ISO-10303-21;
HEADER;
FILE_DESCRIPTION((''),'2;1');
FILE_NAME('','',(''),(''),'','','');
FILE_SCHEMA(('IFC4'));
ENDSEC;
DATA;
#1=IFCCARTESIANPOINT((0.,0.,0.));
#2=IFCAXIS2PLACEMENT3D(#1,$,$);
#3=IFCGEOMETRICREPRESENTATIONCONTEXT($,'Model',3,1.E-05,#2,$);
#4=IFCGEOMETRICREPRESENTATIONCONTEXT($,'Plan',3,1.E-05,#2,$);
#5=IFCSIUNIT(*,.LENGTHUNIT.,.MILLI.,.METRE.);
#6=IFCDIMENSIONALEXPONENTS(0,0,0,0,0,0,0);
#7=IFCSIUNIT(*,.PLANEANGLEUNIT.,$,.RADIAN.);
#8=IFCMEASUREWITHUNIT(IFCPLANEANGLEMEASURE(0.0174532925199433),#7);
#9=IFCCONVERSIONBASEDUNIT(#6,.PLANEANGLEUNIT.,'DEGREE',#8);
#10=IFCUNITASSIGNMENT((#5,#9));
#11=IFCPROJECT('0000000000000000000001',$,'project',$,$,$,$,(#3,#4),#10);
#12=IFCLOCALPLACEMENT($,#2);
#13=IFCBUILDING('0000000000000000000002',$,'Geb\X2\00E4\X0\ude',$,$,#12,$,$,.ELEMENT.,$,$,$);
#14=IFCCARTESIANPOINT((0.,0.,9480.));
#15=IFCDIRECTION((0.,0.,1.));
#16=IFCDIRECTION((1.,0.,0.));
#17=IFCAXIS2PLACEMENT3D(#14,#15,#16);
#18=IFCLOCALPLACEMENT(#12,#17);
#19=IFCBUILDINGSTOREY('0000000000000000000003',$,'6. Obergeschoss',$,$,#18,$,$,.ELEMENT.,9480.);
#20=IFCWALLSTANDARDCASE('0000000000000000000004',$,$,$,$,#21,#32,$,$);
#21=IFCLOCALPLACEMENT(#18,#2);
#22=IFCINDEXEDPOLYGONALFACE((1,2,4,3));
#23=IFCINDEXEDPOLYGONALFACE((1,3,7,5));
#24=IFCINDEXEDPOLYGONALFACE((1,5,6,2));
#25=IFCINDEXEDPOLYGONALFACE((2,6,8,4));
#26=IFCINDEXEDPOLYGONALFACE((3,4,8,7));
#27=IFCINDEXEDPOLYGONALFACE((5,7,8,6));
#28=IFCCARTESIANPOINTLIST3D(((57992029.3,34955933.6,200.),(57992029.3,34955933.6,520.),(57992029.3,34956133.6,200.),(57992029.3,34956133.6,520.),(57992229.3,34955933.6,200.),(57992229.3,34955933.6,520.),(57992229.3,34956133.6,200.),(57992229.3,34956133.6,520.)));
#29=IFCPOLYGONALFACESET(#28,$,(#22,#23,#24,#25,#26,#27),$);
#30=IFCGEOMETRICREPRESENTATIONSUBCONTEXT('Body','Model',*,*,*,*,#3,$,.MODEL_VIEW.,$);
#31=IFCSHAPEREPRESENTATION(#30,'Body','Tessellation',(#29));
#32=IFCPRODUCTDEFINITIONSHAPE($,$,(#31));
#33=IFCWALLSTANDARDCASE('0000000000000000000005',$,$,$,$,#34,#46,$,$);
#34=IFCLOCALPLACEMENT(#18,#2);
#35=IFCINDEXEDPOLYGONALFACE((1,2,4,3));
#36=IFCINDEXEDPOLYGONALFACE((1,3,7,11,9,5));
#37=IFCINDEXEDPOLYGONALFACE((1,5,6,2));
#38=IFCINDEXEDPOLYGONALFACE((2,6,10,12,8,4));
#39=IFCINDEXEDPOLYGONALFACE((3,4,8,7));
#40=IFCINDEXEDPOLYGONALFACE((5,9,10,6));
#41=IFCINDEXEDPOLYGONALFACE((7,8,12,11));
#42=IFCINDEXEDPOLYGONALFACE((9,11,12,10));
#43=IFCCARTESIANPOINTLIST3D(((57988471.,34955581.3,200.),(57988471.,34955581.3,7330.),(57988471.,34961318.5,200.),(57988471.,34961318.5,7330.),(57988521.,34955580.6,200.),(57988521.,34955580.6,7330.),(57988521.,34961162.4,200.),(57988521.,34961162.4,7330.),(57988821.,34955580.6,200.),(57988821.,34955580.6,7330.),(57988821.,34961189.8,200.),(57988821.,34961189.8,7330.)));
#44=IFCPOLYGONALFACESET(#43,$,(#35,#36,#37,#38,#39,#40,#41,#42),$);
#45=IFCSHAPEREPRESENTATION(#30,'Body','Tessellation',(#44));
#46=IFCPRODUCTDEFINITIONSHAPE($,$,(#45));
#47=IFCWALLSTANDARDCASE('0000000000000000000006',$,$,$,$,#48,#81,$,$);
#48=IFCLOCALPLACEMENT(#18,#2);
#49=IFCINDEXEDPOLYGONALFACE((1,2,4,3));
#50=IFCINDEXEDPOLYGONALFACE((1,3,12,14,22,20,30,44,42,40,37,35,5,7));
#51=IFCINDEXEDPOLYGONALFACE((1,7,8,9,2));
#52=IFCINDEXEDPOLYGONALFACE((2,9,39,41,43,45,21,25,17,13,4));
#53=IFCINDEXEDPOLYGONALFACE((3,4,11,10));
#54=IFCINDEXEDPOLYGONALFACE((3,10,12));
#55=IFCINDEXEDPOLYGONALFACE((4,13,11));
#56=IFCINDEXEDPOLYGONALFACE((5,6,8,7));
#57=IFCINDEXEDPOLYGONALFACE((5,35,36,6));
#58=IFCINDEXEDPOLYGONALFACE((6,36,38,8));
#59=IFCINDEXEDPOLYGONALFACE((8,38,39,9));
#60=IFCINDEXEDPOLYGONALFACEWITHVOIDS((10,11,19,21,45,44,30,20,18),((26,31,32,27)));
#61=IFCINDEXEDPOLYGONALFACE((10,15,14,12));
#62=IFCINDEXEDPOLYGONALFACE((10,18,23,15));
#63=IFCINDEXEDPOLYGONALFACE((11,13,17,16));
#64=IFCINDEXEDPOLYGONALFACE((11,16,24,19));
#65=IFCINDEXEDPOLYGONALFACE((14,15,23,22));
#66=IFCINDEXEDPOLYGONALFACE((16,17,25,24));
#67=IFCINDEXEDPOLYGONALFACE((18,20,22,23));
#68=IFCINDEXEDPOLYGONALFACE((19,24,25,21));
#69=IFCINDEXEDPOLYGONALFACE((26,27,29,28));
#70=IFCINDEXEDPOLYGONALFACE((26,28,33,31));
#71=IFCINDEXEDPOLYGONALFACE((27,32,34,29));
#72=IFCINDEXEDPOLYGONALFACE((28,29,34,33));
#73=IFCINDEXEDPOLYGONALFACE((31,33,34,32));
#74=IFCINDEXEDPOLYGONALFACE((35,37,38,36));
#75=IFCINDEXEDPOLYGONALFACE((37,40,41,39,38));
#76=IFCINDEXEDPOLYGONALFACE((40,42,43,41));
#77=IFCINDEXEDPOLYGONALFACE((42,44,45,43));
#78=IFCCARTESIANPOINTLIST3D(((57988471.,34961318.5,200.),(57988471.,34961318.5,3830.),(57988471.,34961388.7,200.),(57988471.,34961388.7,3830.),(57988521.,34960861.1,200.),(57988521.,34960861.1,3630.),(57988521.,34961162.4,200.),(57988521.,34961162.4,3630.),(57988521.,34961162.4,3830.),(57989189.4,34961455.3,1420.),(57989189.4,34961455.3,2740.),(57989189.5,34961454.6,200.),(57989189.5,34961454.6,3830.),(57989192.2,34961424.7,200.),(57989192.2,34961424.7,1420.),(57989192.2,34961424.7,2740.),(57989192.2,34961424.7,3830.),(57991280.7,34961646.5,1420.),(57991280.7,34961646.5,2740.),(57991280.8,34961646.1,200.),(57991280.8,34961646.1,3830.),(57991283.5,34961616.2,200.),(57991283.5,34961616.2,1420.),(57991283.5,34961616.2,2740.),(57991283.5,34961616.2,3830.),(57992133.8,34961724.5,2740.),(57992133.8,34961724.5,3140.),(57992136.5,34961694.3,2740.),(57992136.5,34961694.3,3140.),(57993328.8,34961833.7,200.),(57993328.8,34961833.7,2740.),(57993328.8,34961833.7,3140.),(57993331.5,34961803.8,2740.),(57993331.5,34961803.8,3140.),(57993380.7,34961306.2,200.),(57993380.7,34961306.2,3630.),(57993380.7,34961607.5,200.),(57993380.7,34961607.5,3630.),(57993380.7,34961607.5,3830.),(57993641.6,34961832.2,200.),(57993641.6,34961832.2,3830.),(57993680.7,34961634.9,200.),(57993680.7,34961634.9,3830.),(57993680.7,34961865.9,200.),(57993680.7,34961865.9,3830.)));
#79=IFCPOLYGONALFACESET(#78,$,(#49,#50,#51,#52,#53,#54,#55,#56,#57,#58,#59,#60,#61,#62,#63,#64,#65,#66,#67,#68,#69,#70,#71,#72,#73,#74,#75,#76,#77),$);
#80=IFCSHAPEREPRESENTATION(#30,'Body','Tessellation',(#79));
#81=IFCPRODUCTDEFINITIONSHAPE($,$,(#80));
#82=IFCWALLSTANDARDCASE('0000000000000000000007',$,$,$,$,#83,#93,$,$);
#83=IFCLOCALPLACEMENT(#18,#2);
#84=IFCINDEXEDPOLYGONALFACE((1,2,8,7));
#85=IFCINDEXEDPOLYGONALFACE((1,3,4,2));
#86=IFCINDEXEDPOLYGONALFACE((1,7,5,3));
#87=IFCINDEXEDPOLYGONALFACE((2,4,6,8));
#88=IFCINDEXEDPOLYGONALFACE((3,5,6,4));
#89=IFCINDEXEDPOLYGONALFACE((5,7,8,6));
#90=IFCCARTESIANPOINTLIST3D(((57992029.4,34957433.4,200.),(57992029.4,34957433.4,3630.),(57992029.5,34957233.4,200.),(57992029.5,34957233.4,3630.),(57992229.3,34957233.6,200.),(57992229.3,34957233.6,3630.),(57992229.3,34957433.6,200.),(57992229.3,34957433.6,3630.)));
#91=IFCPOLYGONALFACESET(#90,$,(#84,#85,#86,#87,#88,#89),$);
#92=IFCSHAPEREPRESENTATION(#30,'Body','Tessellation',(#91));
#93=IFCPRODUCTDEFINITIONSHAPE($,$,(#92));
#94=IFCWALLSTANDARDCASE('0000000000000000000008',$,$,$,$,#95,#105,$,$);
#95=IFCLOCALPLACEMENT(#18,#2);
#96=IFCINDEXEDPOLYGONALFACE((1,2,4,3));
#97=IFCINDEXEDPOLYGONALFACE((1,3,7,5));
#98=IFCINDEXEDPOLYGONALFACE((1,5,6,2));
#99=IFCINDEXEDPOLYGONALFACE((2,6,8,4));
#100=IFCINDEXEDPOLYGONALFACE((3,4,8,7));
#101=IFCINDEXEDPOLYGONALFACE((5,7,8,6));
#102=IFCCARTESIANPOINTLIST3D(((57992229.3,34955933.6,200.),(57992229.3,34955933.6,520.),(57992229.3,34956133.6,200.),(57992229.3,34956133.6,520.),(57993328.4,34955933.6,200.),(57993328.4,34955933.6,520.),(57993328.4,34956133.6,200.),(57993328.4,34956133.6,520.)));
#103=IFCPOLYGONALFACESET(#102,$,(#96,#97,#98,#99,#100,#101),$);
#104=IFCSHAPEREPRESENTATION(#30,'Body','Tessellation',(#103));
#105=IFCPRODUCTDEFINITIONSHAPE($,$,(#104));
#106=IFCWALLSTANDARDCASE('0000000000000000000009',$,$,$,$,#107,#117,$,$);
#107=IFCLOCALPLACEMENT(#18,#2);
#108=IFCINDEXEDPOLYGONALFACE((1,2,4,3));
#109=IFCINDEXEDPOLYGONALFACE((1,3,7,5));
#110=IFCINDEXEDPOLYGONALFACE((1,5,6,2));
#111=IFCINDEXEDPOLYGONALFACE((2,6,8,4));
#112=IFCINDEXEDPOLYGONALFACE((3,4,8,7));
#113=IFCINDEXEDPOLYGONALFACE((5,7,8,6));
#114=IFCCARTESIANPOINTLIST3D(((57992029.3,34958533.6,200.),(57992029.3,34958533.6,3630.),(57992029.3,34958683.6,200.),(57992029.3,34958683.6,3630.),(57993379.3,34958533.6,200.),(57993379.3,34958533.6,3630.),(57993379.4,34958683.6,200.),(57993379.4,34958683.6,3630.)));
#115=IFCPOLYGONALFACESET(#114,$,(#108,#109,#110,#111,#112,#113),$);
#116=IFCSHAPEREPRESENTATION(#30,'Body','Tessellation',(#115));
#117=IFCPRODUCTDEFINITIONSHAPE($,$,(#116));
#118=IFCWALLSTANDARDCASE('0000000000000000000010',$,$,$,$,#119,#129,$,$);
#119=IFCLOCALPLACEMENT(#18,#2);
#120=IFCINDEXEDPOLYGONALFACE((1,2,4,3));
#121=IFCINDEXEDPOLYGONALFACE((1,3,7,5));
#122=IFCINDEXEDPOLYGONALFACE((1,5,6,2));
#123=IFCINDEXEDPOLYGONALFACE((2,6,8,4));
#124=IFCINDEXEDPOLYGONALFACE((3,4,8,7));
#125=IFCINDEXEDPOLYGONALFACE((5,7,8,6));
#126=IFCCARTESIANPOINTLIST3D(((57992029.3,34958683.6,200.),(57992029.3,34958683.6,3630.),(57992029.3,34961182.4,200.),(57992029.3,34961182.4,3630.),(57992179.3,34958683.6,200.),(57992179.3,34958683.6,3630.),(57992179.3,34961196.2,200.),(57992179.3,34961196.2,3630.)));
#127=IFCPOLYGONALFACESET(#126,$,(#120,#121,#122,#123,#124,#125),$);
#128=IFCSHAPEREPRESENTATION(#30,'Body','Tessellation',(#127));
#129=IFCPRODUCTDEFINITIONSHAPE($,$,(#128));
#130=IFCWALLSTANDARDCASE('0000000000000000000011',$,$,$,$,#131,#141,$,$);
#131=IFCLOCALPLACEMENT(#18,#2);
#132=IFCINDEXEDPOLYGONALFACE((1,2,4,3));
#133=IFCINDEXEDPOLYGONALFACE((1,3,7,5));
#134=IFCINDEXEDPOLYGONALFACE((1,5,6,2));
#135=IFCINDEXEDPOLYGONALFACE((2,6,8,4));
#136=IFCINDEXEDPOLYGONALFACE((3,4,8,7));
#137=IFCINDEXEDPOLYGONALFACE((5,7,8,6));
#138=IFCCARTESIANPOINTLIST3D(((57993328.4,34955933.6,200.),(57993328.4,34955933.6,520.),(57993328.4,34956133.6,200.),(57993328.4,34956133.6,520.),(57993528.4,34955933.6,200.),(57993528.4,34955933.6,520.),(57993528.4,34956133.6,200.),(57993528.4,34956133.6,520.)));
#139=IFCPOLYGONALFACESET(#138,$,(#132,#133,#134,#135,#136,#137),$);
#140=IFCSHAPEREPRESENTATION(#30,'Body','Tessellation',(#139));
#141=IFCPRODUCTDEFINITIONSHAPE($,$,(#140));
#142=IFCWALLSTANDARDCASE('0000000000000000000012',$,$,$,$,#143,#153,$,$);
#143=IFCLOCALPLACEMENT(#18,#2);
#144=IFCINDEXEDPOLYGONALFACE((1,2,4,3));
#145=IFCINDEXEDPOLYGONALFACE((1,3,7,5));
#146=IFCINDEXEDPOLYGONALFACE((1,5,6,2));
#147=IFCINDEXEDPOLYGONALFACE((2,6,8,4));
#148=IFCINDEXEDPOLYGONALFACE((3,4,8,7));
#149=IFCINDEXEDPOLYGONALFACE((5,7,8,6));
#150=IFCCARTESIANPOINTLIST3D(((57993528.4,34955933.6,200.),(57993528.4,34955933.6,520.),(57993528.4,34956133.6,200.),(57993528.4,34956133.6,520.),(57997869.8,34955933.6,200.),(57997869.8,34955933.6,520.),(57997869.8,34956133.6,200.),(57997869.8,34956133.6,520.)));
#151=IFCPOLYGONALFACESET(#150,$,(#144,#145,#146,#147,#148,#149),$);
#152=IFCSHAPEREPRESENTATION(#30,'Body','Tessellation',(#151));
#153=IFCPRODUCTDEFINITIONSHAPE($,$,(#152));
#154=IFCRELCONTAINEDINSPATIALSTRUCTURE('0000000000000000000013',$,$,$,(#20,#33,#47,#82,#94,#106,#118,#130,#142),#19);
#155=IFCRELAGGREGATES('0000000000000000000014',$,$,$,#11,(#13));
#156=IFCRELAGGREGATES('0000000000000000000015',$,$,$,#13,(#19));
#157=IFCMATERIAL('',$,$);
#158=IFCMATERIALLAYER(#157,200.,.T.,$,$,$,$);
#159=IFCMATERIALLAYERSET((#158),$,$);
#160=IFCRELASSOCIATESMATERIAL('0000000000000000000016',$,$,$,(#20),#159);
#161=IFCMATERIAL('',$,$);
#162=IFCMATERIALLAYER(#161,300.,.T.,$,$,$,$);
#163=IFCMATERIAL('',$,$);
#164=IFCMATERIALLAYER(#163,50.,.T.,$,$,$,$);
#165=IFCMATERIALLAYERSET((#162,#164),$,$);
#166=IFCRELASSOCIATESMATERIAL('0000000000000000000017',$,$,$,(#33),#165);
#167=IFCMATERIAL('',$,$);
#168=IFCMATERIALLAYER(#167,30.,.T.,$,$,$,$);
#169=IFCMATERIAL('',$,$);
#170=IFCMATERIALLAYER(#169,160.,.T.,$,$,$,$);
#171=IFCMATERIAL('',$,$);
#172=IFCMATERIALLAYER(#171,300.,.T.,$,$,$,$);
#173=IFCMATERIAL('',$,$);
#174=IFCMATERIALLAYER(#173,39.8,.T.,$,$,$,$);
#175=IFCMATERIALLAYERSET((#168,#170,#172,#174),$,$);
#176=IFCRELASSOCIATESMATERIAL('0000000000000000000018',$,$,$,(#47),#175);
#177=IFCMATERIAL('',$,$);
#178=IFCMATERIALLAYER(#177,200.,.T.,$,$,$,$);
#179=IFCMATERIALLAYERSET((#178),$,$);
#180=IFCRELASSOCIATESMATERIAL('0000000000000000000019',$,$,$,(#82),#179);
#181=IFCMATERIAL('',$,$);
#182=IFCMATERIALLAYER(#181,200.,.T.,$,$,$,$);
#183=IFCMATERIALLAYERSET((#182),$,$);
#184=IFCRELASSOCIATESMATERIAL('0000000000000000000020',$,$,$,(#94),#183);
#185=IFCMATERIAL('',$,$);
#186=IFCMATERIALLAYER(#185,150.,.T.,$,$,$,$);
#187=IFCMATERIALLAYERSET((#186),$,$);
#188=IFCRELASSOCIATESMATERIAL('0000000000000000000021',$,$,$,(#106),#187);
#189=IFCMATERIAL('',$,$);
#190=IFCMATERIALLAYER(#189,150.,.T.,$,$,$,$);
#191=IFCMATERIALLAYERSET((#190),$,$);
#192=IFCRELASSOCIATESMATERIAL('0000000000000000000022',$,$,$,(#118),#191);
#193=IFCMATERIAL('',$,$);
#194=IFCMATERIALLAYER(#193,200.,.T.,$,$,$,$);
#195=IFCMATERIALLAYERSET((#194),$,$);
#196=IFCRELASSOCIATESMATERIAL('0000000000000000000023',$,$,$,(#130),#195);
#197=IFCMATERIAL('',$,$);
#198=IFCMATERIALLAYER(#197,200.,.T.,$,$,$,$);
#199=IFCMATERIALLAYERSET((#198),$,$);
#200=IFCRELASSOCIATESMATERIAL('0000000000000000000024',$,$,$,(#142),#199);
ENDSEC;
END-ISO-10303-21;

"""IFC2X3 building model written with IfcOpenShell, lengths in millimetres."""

from ifc_helpers import new_model, entity, si_unit, converted_unit, frame, frame_2d, origin, origin_with_axes, place, context, subcontext, project, spatial, polyline, rectangle, outline, extrude, clip, bounded_halfspace, material, layer, layer_set, layer_usage, element, save


model = new_model("IFC2X3")

# Units and contexts
model_context = context("Model", 3, precision=1e-05, world=origin())
plan_context = context("Plan", 3, precision=1e-05, world=origin())
body_context = subcontext(model_context, "Body", "Model", "MODEL_VIEW")
ifc_project = project(units=[si_unit("LENGTHUNIT", "METRE", prefix="MILLI"), converted_unit("PLANEANGLEUNIT", "DEGREE", entity("IfcPlaneAngleMeasure", 0.0174532925199433), si_unit("PLANEANGLEUNIT", "RADIAN"), dimensions=[0, 0, 0, 0, 0, 0, 0])], contexts=[model_context, plan_context])

# Building, storey
building_placement = place(None, origin())
building = spatial("IfcBuilding", under=ifc_project, at=building_placement, Name="Gebäude", CompositionType="ELEMENT")
storey_placement = place(building_placement, frame((0.0, 0.0, 9480.0), z_axis=(0.0, 0.0, 1.0), x_axis=(1.0, 0.0, 0.0)))
storey = spatial("IfcBuildingStorey", under=building, at=storey_placement, Name="6. Obergeschoss", CompositionType="ELEMENT", Elevation=9480.0)

# Walls
ifc_material_1 = material(Name="")
ifc_layer_1 = layer(ifc_material_1, 200.0, ventilated=True)
ifc_layer_set_1 = layer_set([ifc_layer_1])
ifc_layer_usage_1 = layer_usage(ifc_layer_set_1, "AXIS2", "POSITIVE", 0.0)
wall_1_placement = place(storey_placement, frame((57992029.3, 34955933.6, 200.0), z_axis=(0.0, 0.0, 1.0), x_axis=(1.0, 0.0, 0.0)))
element("IfcWallStandardCase", 1, at=wall_1_placement, inside=storey, material=ifc_layer_usage_1, context=body_context, shape_type="SweptSolid", body=[
    extrude(rectangle(XDim=200.0, YDim=200.0, at=frame_2d((100.0, 100.0), x_axis=(1.0, 0.0))), origin_with_axes(), (0.0, 0.0, 1.0), 320.0),
])
ifc_material_2 = material(Name="")
ifc_layer_2 = layer(ifc_material_2, 300.0, ventilated=True)
ifc_material_3 = material(Name="")
ifc_layer_3 = layer(ifc_material_3, 50.0, ventilated=True)
ifc_layer_set_2 = layer_set([ifc_layer_2, ifc_layer_3])
ifc_layer_usage_2 = layer_usage(ifc_layer_set_2, "AXIS2", "POSITIVE", 0.0)
wall_2_placement = place(storey_placement, frame((57988821.0, 34955580.6, 200.0), z_axis=(0.0, 0.0, 1.0), x_axis=(0.0, 1.0, 0.0)))
element("IfcWallStandardCase", 2, at=wall_2_placement, inside=storey, material=ifc_layer_usage_2, context=body_context, shape_type="SweptSolid", body=[
    extrude(outline(polyline([(0.0, 0.0), (5609.3, 0.0), (5581.8, 300.0), (5737.9, 350.0), (0.7, 350.0), (0.0, 300.0), (0.0, 0.0)])), origin_with_axes(), (0.0, 0.0, 1.0), 7130.0),
])

# Wall, openings
ifc_material_4 = material(Name="")
ifc_layer_4 = layer(ifc_material_4, 30.0, ventilated=True)
ifc_material_5 = material(Name="")
ifc_layer_5 = layer(ifc_material_5, 160.0, ventilated=True)
ifc_material_6 = material(Name="")
ifc_layer_6 = layer(ifc_material_6, 300.0, ventilated=True)
ifc_material_7 = material(Name="")
ifc_layer_7 = layer(ifc_material_7, 39.8, ventilated=True)
ifc_layer_set_3 = layer_set([ifc_layer_4, ifc_layer_5, ifc_layer_6, ifc_layer_7])
ifc_layer_usage_3 = layer_usage(ifc_layer_set_3, "AXIS2", "POSITIVE", 0.0)
wall_3_placement = place(storey_placement, frame((57989192.2, 34961424.7, 200.0), z_axis=(0.0, 0.0, 1.0), x_axis=(0.995832, 0.091206, 0.0)))
wall_3 = element("IfcWallStandardCase", 3, at=wall_3_placement, inside=storey, material=ifc_layer_usage_3, context=body_context, shape_type="Clipping", body=[
    clip(clip(extrude(outline(polyline([(4510.0, 30.0), (4461.5, 30.0), (4208.8, 30.0), (4156.6, 30.0), (-721.5, 30.0), (-724.2, 0.4), (-727.9, -40.0), (-692.3, -200.0), (-719.8, -500.0), (4160.2, -500.0), (4187.7, -200.0), (4468.0, 0.0), (4472.2, -40.0), (4489.0, -200.0), (4507.3, 0.0), (4510.0, 30.0)])), origin_with_axes(), (0.0, 0.0, 1.0), 3630.0), bounded_halfspace(frame((-719.8, -500.0, 3430.0), z_axis=(0.0, 0.0, -1.0), x_axis=(1.0, 0.0, 0.0)), True, origin(), polyline([(-719.8, -500.0), (4160.2, -500.0), (4187.7, -200.0), (-692.3, -200.0), (-719.8, -500.0)]))), bounded_halfspace(frame((-692.3, -200.0, 3630.0), z_axis=(0.0, 0.0, -1.0), x_axis=(1.0, 0.0, 0.0)), True, origin(), polyline([(-692.3, -200.0), (4187.7, -200.0), (4468.0, 0.0), (4489.0, -200.0), (4510.0, 30.0), (4461.5, 30.0), (4208.8, 30.0), (4156.6, 30.0), (-721.5, 30.0), (-727.9, -40.0), (-692.3, -200.0)]))),
])
opening_1_placement = place(wall_3_placement, frame((0.0, 0.0, 2540.0), z_axis=(0.0, 1.0, 0.0), x_axis=(0.0, 0.0, 1.0)))
element("IfcOpeningElement", 4, at=opening_1_placement, cuts=wall_3, ObjectType="Opening", context=body_context, shape_type="SweptSolid", body=[
    extrude(rectangle(XDim=1200.0, YDim=2100.0, at=frame_2d((600.0, 1050.0), x_axis=(1.0, 0.0))), origin_with_axes(), (0.0, 0.0, 1.0), 530.0),
])
opening_2_placement = place(wall_3_placement, frame((2956.6, 0.0, 2540.0), z_axis=(0.0, 1.0, 0.0), x_axis=(0.0, 0.0, 1.0)))
element("IfcOpeningElement", 5, at=opening_2_placement, cuts=wall_3, ObjectType="Opening", context=body_context, shape_type="SweptSolid", body=[
    extrude(rectangle(XDim=400.0, YDim=1200.0, at=frame_2d((200.0, 600.0), x_axis=(1.0, 0.0))), origin_with_axes(), (0.0, 0.0, 1.0), 530.0),
])
opening_3_placement = place(wall_3_placement, frame((0.0, 0.0, -420.0), z_axis=(0.0, 1.0, 0.0), x_axis=(0.0, 0.0, 1.0)))
element("IfcOpeningElement", 6, at=opening_3_placement, cuts=wall_3, ObjectType="Opening", context=body_context, shape_type="SweptSolid", body=[
    extrude(rectangle(XDim=1640.0, YDim=2100.0, at=frame_2d((820.0, 1050.0), x_axis=(1.0, 0.0))), origin_with_axes(), (0.0, 0.0, 1.0), 530.0),
])

# Walls
ifc_material_8 = material(Name="")
ifc_layer_8 = layer(ifc_material_8, 200.0, ventilated=True)
ifc_layer_set_4 = layer_set([ifc_layer_8])
ifc_layer_usage_4 = layer_usage(ifc_layer_set_4, "AXIS2", "POSITIVE", 0.0)
wall_4_placement = place(storey_placement, frame((57992229.3, 34957433.6, 200.0), z_axis=(0.0, 0.0, 1.0), x_axis=(-1.0, -0.000827, 0.0)))
element("IfcWallStandardCase", 7, at=wall_4_placement, inside=storey, material=ifc_layer_usage_4, context=body_context, shape_type="SweptSolid", body=[
    extrude(outline(polyline([(0.0, 0.0), (200.0, 0.0), (200.0, 200.0), (0.2, 200.0), (0.0, 0.0)])), origin_with_axes(), (0.0, 0.0, 1.0), 3430.0),
])
ifc_material_9 = material(Name="")
ifc_layer_9 = layer(ifc_material_9, 200.0, ventilated=True)
ifc_layer_set_5 = layer_set([ifc_layer_9])
ifc_layer_usage_5 = layer_usage(ifc_layer_set_5, "AXIS2", "POSITIVE", 0.0)
wall_5_placement = place(storey_placement, frame((57992229.3, 34955933.6, 200.0), z_axis=(0.0, 0.0, 1.0), x_axis=(1.0, 0.0, 0.0)))
element("IfcWallStandardCase", 8, at=wall_5_placement, inside=storey, material=ifc_layer_usage_5, context=body_context, shape_type="SweptSolid", body=[
    extrude(rectangle(XDim=1099.1, YDim=200.0, at=frame_2d((549.6, 100.0), x_axis=(1.0, 0.0))), origin_with_axes(), (0.0, 0.0, 1.0), 320.0),
])
ifc_material_10 = material(Name="")
ifc_layer_10 = layer(ifc_material_10, 150.0, ventilated=True)
ifc_layer_set_6 = layer_set([ifc_layer_10])
ifc_layer_usage_6 = layer_usage(ifc_layer_set_6, "AXIS2", "POSITIVE", 0.0)
wall_6_placement = place(storey_placement, frame((57992029.3, 34958533.6, 200.0), z_axis=(0.0, 0.0, 1.0), x_axis=(1.0, -0.000001, 0.0)))
element("IfcWallStandardCase", 9, at=wall_6_placement, inside=storey, material=ifc_layer_usage_6, context=body_context, shape_type="SweptSolid", body=[
    extrude(outline(polyline([(0.0, 0.0), (1350.0, 0.0), (1350.1, 150.0), (0.0, 150.0), (0.0, 0.0)])), origin_with_axes(), (0.0, 0.0, 1.0), 3430.0),
])
ifc_material_11 = material(Name="")
ifc_layer_11 = layer(ifc_material_11, 150.0, ventilated=True)
ifc_layer_set_7 = layer_set([ifc_layer_11])
ifc_layer_usage_7 = layer_usage(ifc_layer_set_7, "AXIS2", "POSITIVE", 0.0)
wall_7_placement = place(storey_placement, frame((57992029.3, 34961182.4, 200.0), z_axis=(0.0, 0.0, 1.0), x_axis=(0.0, -1.0, 0.0)))
element("IfcWallStandardCase", 10, at=wall_7_placement, inside=storey, material=ifc_layer_usage_7, context=body_context, shape_type="SweptSolid", body=[
    extrude(outline(polyline([(0.0, 0.0), (2498.9, 0.0), (2498.9, 150.0), (-13.7, 150.0), (0.0, 0.0)])), origin_with_axes(), (0.0, 0.0, 1.0), 3430.0),
])
ifc_material_12 = material(Name="")
ifc_layer_12 = layer(ifc_material_12, 200.0, ventilated=True)
ifc_layer_set_8 = layer_set([ifc_layer_12])
ifc_layer_usage_8 = layer_usage(ifc_layer_set_8, "AXIS2", "POSITIVE", 0.0)
wall_8_placement = place(storey_placement, frame((57993328.4, 34955933.6, 200.0), z_axis=(0.0, 0.0, 1.0), x_axis=(1.0, -0.000002, 0.0)))
element("IfcWallStandardCase", 11, at=wall_8_placement, inside=storey, material=ifc_layer_usage_8, context=body_context, shape_type="SweptSolid", body=[
    extrude(outline(polyline([(0.0, 0.0), (200.0, 0.0), (200.0, 200.0), (0.0, 200.0), (0.0, 0.0)])), origin_with_axes(), (0.0, 0.0, 1.0), 320.0),
])
ifc_material_13 = material(Name="")
ifc_layer_13 = layer(ifc_material_13, 200.0, ventilated=True)
ifc_layer_set_9 = layer_set([ifc_layer_13])
ifc_layer_usage_9 = layer_usage(ifc_layer_set_9, "AXIS2", "POSITIVE", 0.0)
wall_9_placement = place(storey_placement, frame((57997869.8, 34956133.6, 200.0), z_axis=(0.0, 0.0, 1.0), x_axis=(-1.0, 0.0, 0.0)))
element("IfcWallStandardCase", 12, at=wall_9_placement, inside=storey, material=ifc_layer_usage_9, context=body_context, shape_type="SweptSolid", body=[
    extrude(rectangle(XDim=4341.4, YDim=200.0, at=frame_2d((2170.7, 100.0), x_axis=(1.0, 0.0))), origin_with_axes(), (0.0, 0.0, 1.0), 320.0),
])

save(model, "model.ifc")
